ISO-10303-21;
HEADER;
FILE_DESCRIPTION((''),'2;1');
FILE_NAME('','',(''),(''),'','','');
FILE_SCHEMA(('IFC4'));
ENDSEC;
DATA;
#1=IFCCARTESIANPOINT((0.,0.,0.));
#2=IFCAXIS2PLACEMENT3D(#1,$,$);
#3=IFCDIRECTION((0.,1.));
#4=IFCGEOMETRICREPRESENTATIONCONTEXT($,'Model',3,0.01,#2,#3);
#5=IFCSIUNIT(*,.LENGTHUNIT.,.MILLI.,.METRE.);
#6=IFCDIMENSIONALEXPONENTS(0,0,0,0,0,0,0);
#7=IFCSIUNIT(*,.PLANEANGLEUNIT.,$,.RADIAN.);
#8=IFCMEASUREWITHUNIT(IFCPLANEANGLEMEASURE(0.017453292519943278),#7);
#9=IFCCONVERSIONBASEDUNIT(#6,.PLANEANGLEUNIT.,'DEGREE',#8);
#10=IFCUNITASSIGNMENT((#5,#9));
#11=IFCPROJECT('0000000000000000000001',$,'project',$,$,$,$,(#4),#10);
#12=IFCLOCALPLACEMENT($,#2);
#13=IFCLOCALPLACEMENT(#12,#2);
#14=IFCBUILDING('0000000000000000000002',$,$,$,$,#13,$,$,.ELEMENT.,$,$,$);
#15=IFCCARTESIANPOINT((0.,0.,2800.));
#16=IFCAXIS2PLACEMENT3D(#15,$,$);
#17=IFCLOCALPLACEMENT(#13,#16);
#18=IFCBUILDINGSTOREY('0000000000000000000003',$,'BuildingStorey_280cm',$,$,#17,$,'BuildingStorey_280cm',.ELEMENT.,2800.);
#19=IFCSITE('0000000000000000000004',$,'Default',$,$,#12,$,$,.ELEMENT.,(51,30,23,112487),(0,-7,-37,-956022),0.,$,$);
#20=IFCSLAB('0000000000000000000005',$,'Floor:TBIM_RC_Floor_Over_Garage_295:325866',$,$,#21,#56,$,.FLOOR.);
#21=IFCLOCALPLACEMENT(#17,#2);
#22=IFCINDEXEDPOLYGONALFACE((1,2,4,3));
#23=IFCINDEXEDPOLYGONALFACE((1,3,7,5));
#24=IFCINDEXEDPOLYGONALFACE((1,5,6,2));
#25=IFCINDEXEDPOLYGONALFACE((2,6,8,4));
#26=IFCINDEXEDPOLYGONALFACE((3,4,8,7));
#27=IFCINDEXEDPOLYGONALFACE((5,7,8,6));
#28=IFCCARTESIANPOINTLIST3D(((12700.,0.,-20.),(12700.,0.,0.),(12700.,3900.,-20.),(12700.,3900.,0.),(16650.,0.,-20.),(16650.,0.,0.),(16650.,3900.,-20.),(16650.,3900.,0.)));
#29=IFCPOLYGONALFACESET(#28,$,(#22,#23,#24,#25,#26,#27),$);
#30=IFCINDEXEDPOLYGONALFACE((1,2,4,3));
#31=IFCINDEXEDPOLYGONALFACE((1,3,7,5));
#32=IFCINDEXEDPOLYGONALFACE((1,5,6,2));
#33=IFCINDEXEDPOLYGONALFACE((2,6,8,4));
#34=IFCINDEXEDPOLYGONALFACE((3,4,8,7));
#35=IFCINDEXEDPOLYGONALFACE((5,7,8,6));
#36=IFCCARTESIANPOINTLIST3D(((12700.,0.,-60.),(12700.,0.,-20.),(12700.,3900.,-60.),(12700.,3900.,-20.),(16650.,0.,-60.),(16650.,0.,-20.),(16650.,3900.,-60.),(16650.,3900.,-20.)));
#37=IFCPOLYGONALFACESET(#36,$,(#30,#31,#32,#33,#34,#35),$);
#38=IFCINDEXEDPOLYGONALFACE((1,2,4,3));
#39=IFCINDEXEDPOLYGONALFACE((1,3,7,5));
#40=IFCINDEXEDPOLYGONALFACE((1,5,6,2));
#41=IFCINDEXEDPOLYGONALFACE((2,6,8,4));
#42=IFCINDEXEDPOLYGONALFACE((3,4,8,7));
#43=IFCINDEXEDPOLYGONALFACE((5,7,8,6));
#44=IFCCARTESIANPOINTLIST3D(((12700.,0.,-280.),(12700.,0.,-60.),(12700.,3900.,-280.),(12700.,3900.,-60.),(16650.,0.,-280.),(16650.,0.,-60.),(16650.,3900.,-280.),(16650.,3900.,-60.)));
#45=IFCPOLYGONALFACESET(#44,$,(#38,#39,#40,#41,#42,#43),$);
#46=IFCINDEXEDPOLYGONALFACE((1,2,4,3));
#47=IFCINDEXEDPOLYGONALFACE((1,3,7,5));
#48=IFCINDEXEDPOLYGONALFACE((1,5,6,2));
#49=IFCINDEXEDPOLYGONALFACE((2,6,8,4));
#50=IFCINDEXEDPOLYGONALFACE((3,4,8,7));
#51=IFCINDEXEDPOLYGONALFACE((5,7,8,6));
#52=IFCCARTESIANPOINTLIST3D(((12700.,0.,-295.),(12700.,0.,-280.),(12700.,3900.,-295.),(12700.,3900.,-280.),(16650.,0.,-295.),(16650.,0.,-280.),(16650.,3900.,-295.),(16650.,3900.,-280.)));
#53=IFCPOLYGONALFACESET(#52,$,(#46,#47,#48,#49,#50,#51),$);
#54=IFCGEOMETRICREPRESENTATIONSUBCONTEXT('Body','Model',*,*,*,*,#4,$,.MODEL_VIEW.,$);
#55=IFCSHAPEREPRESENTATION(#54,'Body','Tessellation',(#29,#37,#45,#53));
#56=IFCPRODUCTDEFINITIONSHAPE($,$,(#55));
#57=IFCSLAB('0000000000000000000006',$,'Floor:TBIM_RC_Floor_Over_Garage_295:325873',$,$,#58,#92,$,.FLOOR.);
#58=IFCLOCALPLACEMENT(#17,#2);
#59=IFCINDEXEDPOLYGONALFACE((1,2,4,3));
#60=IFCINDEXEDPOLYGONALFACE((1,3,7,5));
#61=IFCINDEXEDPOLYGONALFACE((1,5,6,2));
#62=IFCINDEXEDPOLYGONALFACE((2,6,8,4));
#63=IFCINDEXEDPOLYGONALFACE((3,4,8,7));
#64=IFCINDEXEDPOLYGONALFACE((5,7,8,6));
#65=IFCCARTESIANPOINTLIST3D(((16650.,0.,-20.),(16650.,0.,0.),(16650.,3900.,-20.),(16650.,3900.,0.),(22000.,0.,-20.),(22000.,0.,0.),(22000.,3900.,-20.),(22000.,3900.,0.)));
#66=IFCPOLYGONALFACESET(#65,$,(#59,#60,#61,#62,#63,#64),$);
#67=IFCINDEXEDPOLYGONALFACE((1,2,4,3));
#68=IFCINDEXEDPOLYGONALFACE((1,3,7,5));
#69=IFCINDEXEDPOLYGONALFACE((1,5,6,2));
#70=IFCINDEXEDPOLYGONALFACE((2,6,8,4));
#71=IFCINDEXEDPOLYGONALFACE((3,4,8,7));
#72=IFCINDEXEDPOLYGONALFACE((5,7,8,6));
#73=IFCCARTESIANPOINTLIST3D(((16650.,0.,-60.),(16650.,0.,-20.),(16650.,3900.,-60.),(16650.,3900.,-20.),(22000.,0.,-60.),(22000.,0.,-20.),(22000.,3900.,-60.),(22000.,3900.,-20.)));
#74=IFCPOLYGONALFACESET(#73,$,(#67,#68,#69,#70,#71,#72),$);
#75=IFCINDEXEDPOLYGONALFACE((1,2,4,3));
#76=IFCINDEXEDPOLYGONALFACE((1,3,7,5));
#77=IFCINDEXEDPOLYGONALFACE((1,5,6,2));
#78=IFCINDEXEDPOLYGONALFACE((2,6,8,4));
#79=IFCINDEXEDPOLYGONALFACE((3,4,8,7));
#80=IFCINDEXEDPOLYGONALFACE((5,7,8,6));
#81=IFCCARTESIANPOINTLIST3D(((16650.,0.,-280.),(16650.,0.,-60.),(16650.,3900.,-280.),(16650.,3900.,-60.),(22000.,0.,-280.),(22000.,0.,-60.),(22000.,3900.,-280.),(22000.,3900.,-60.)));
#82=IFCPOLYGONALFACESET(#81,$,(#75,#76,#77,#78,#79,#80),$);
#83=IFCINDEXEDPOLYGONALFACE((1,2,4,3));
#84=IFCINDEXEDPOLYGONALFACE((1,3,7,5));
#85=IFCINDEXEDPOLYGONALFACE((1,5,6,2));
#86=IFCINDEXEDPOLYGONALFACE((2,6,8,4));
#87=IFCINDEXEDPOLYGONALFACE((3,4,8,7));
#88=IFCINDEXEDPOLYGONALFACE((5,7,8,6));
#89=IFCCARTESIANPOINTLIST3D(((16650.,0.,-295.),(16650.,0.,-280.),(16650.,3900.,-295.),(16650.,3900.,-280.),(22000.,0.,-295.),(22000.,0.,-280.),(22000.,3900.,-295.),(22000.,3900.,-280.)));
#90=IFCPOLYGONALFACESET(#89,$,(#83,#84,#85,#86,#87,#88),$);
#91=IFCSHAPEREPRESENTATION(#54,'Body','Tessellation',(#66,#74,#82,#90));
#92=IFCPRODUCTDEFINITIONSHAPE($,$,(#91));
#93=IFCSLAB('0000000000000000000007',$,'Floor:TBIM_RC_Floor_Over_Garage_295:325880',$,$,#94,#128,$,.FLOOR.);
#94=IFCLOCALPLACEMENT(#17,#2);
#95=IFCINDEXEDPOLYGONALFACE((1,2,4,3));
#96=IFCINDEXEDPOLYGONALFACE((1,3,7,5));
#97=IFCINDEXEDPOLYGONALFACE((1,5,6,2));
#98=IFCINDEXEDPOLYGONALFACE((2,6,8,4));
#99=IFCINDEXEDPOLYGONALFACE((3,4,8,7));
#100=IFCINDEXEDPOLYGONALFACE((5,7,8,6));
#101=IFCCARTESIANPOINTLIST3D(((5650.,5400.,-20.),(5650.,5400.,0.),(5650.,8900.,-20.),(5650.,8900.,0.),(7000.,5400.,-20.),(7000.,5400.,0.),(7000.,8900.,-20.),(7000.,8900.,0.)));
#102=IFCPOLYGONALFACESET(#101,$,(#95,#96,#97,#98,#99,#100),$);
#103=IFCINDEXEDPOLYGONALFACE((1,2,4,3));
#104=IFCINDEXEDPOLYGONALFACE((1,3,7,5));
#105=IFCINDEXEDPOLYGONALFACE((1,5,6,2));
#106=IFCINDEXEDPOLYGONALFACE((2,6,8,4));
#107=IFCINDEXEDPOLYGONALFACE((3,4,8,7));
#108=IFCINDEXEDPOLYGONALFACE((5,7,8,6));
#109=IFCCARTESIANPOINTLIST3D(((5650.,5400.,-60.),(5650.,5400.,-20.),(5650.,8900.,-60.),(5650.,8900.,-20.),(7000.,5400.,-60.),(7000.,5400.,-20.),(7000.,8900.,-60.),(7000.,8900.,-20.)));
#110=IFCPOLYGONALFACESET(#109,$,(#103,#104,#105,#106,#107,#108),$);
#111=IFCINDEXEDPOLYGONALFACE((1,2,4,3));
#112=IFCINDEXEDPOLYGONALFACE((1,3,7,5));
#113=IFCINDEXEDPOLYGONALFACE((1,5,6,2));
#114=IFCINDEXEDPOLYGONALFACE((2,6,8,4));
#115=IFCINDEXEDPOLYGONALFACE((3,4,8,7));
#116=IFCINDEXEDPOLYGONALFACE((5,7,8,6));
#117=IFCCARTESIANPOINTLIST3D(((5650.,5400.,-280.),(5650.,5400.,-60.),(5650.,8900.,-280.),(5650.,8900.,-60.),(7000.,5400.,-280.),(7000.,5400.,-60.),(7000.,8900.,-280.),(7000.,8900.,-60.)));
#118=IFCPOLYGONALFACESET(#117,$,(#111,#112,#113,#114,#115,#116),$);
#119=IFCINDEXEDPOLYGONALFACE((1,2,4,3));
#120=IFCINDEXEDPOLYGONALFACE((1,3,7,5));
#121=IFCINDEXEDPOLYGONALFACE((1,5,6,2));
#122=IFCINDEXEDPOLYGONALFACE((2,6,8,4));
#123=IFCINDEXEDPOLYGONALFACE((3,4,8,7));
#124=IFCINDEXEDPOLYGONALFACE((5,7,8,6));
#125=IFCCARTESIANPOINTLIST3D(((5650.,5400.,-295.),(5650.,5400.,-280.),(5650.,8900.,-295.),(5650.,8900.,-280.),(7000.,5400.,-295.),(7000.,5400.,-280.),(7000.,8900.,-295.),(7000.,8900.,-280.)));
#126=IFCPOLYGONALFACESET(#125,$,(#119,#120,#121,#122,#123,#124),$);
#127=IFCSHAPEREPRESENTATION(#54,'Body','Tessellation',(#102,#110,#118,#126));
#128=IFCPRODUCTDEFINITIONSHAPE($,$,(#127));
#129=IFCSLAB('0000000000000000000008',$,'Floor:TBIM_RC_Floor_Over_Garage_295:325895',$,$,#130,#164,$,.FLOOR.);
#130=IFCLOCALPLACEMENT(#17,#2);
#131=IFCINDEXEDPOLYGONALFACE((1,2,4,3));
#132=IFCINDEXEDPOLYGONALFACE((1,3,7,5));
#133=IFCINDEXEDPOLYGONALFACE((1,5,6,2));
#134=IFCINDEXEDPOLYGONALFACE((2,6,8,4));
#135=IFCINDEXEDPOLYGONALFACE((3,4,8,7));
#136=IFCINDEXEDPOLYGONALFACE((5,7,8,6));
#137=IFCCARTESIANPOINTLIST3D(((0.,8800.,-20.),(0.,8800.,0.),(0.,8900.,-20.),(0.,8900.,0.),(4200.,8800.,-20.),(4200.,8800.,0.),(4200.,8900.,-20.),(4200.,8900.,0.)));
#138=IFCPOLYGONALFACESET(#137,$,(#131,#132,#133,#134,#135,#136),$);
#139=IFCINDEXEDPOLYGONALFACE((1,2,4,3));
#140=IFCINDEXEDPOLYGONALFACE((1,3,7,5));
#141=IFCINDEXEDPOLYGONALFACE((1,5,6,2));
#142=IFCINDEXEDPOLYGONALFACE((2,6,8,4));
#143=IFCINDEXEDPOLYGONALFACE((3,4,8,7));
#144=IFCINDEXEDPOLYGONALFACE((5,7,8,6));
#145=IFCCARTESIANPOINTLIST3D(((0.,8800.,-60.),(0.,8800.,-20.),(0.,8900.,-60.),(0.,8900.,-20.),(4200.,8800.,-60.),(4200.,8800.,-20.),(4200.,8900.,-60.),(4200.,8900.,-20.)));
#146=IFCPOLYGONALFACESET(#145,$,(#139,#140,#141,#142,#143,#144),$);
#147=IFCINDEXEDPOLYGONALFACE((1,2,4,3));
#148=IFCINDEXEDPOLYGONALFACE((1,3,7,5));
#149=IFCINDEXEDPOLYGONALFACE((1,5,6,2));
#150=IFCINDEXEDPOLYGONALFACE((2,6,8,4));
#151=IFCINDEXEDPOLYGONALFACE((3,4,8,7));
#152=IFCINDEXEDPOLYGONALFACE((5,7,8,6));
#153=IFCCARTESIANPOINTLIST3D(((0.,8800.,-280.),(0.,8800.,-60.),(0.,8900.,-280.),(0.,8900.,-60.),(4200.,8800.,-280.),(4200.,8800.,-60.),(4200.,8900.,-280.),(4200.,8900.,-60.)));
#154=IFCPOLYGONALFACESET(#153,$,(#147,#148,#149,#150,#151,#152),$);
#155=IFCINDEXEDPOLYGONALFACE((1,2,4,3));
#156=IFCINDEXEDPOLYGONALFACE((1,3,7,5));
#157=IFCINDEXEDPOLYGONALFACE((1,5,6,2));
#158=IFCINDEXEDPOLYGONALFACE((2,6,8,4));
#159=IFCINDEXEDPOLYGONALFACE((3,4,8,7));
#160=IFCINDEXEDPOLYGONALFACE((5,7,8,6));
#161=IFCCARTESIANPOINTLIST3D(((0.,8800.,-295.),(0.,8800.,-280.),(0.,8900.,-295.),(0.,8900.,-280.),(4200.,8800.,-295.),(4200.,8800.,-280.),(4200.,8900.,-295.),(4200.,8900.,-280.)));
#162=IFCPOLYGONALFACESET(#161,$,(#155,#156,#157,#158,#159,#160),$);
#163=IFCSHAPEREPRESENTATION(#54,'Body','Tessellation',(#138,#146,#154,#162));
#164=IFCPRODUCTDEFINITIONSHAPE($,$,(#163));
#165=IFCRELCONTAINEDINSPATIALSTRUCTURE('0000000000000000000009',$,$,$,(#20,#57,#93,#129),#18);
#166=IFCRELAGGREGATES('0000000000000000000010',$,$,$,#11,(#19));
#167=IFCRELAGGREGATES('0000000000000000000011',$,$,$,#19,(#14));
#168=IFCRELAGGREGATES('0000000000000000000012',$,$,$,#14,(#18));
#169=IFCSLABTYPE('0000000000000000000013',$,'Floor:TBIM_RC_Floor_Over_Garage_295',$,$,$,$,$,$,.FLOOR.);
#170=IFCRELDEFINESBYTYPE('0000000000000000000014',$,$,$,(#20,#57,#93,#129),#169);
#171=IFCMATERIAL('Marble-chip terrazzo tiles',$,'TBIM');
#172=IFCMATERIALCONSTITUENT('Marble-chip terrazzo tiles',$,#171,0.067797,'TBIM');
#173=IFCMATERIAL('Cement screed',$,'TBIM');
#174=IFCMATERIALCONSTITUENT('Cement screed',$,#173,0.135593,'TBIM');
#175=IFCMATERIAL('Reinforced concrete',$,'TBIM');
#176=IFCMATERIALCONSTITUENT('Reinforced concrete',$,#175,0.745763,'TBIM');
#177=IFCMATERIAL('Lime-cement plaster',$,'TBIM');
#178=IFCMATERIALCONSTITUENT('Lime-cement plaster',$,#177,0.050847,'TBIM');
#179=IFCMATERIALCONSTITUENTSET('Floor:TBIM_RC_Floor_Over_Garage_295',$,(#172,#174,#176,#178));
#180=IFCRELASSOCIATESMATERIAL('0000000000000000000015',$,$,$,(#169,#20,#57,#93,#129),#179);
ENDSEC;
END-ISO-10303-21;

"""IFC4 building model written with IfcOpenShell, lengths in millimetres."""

from ifc_helpers import new_model, entity, si_unit, converted_unit, direction, frame, origin, place, context, subcontext, project, spatial, indexed_curve, outline, extrude, material, constituent, constituent_set, type_object, element, save


model = new_model("IFC4")

# Units and contexts
model_context = context("Model", 3, precision=0.01, world=origin(), true_north=direction((0.0, 1.0)))
body_context = subcontext(model_context, "Body", "Model", "MODEL_VIEW")
ifc_project = project(units=[si_unit("LENGTHUNIT", "METRE", prefix="MILLI"), converted_unit("PLANEANGLEUNIT", "DEGREE", entity("IfcPlaneAngleMeasure", 0.017453292519943278), si_unit("PLANEANGLEUNIT", "RADIAN"), dimensions=[0, 0, 0, 0, 0, 0, 0])], contexts=[model_context])

# Site, building, storey
site_placement = place(None, origin())
site = spatial("IfcSite", under=ifc_project, at=site_placement, Name="Default", CompositionType="ELEMENT", RefLatitude=(51, 30, 23, 112487), RefLongitude=(0, -7, -37, -956022), RefElevation=0.0)
building_placement = place(site_placement, origin())
building = spatial("IfcBuilding", under=site, at=building_placement, CompositionType="ELEMENT")
storey_placement = place(building_placement, frame((0.0, 0.0, 2800.0)))
storey = spatial("IfcBuildingStorey", under=building, at=storey_placement, Name="BuildingStorey_280cm", LongName="BuildingStorey_280cm", CompositionType="ELEMENT", Elevation=2800.0)

# Slabs
ifc_material_1 = material(Name="Marble-chip terrazzo tiles", Category="TBIM")
ifc_constituent_1 = constituent(ifc_material_1, Name="Marble-chip terrazzo tiles", Category="TBIM", fraction=0.067797)
ifc_material_2 = material(Name="Cement screed", Category="TBIM")
ifc_constituent_2 = constituent(ifc_material_2, Name="Cement screed", Category="TBIM", fraction=0.135593)
ifc_material_3 = material(Name="Reinforced concrete", Category="TBIM")
ifc_constituent_3 = constituent(ifc_material_3, Name="Reinforced concrete", Category="TBIM", fraction=0.745763)
ifc_material_4 = material(Name="Lime-cement plaster", Category="TBIM")
ifc_constituent_4 = constituent(ifc_material_4, Name="Lime-cement plaster", Category="TBIM", fraction=0.050847)
ifc_constituent_set_1 = constituent_set(constituents=[ifc_constituent_1, ifc_constituent_2, ifc_constituent_3, ifc_constituent_4], Name="Floor:TBIM_RC_Floor_Over_Garage_295")
slab_type_1 = type_object("IfcSlabType", Name="Floor:TBIM_RC_Floor_Over_Garage_295", PredefinedType="FLOOR", material=ifc_constituent_set_1)
slab_1_placement = place(storey_placement, origin())
element("IfcSlab", 1, at=slab_1_placement, inside=storey, type_object=slab_type_1, material=ifc_constituent_set_1, Name="Floor:TBIM_RC_Floor_Over_Garage_295:325866", PredefinedType="FLOOR", context=body_context, shape_type="SweptSolid", body=[
    extrude(outline(indexed_curve([(-1975.0, -1950.0), (1975.0, -1950.0), (1975.0, 1950.0), (-1975.0, 1950.0), (-1975.0, -1950.0)], self_intersect=False)), frame((14675.0, 1950.0, -20.0), z_axis=(0.0, 0.0, 1.0), x_axis=(-1.0, 0.0, 0.0)), (0.0, 0.0, 1.0), 20.0),
    extrude(outline(indexed_curve([(-1975.0, -1950.0), (1975.0, -1950.0), (1975.0, 1950.0), (-1975.0, 1950.0), (-1975.0, -1950.0)], self_intersect=False)), frame((14675.0, 1950.0, -60.0), z_axis=(0.0, 0.0, 1.0), x_axis=(-1.0, 0.0, 0.0)), (0.0, 0.0, 1.0), 40.0),
    extrude(outline(indexed_curve([(-1975.0, -1950.0), (1975.0, -1950.0), (1975.0, 1950.0), (-1975.0, 1950.0), (-1975.0, -1950.0)], self_intersect=False)), frame((14675.0, 1950.0, -280.0), z_axis=(0.0, 0.0, 1.0), x_axis=(-1.0, 0.0, 0.0)), (0.0, 0.0, 1.0), 220.0),
    extrude(outline(indexed_curve([(-1975.0, -1950.0), (1975.0, -1950.0), (1975.0, 1950.0), (-1975.0, 1950.0), (-1975.0, -1950.0)], self_intersect=False)), frame((14675.0, 1950.0, -295.0), z_axis=(0.0, 0.0, 1.0), x_axis=(-1.0, 0.0, 0.0)), (0.0, 0.0, 1.0), 15.0),
])
slab_2_placement = place(storey_placement, origin())
element("IfcSlab", 2, at=slab_2_placement, inside=storey, type_object=slab_type_1, material=ifc_constituent_set_1, Name="Floor:TBIM_RC_Floor_Over_Garage_295:325873", PredefinedType="FLOOR", context=body_context, shape_type="SweptSolid", body=[
    extrude(outline(indexed_curve([(-2675.0, -1950.0), (2675.0, -1950.0), (2675.0, 1950.0), (-2675.0, 1950.0), (-2675.0, -1950.0)], self_intersect=False)), frame((19325.0, 1950.0, -20.0), z_axis=(0.0, 0.0, 1.0), x_axis=(-1.0, 0.0, 0.0)), (0.0, 0.0, 1.0), 20.0),
    extrude(outline(indexed_curve([(-2675.0, -1950.0), (2675.0, -1950.0), (2675.0, 1950.0), (-2675.0, 1950.0), (-2675.0, -1950.0)], self_intersect=False)), frame((19325.0, 1950.0, -60.0), z_axis=(0.0, 0.0, 1.0), x_axis=(-1.0, 0.0, 0.0)), (0.0, 0.0, 1.0), 40.0),
    extrude(outline(indexed_curve([(-2675.0, -1950.0), (2675.0, -1950.0), (2675.0, 1950.0), (-2675.0, 1950.0), (-2675.0, -1950.0)], self_intersect=False)), frame((19325.0, 1950.0, -280.0), z_axis=(0.0, 0.0, 1.0), x_axis=(-1.0, 0.0, 0.0)), (0.0, 0.0, 1.0), 220.0),
    extrude(outline(indexed_curve([(-2675.0, -1950.0), (2675.0, -1950.0), (2675.0, 1950.0), (-2675.0, 1950.0), (-2675.0, -1950.0)], self_intersect=False)), frame((19325.0, 1950.0, -295.0), z_axis=(0.0, 0.0, 1.0), x_axis=(-1.0, 0.0, 0.0)), (0.0, 0.0, 1.0), 15.0),
])
slab_3_placement = place(storey_placement, origin())
element("IfcSlab", 3, at=slab_3_placement, inside=storey, type_object=slab_type_1, material=ifc_constituent_set_1, Name="Floor:TBIM_RC_Floor_Over_Garage_295:325880", PredefinedType="FLOOR", context=body_context, shape_type="SweptSolid", body=[
    extrude(outline(indexed_curve([(-675.0, -1750.0), (675.0, -1750.0), (675.0, 1750.0), (-675.0, 1750.0), (-675.0, -1750.0)], self_intersect=False)), frame((6325.0, 7150.0, -20.0), z_axis=(0.0, 0.0, 1.0), x_axis=(-1.0, 0.0, 0.0)), (0.0, 0.0, 1.0), 20.0),
    extrude(outline(indexed_curve([(-675.0, -1750.0), (675.0, -1750.0), (675.0, 1750.0), (-675.0, 1750.0), (-675.0, -1750.0)], self_intersect=False)), frame((6325.0, 7150.0, -60.0), z_axis=(0.0, 0.0, 1.0), x_axis=(-1.0, 0.0, 0.0)), (0.0, 0.0, 1.0), 40.0),
    extrude(outline(indexed_curve([(-675.0, -1750.0), (675.0, -1750.0), (675.0, 1750.0), (-675.0, 1750.0), (-675.0, -1750.0)], self_intersect=False)), frame((6325.0, 7150.0, -280.0), z_axis=(0.0, 0.0, 1.0), x_axis=(-1.0, 0.0, 0.0)), (0.0, 0.0, 1.0), 220.0),
    extrude(outline(indexed_curve([(-675.0, -1750.0), (675.0, -1750.0), (675.0, 1750.0), (-675.0, 1750.0), (-675.0, -1750.0)], self_intersect=False)), frame((6325.0, 7150.0, -295.0), z_axis=(0.0, 0.0, 1.0), x_axis=(-1.0, 0.0, 0.0)), (0.0, 0.0, 1.0), 15.0),
])
slab_4_placement = place(storey_placement, origin())
element("IfcSlab", 4, at=slab_4_placement, inside=storey, type_object=slab_type_1, material=ifc_constituent_set_1, Name="Floor:TBIM_RC_Floor_Over_Garage_295:325895", PredefinedType="FLOOR", context=body_context, shape_type="SweptSolid", body=[
    extrude(outline(indexed_curve([(-2100.0, -50.0), (2100.0, -50.0), (2100.0, 50.0), (-2100.0, 50.0), (-2100.0, -50.0)], self_intersect=False)), frame((2100.0, 8850.0, -20.0), z_axis=(0.0, 0.0, 1.0), x_axis=(-1.0, 0.0, 0.0)), (0.0, 0.0, 1.0), 20.0),
    extrude(outline(indexed_curve([(-2100.0, -50.0), (2100.0, -50.0), (2100.0, 50.0), (-2100.0, 50.0), (-2100.0, -50.0)], self_intersect=False)), frame((2100.0, 8850.0, -60.0), z_axis=(0.0, 0.0, 1.0), x_axis=(-1.0, 0.0, 0.0)), (0.0, 0.0, 1.0), 40.0),
    extrude(outline(indexed_curve([(-2100.0, -50.0), (2100.0, -50.0), (2100.0, 50.0), (-2100.0, 50.0), (-2100.0, -50.0)], self_intersect=False)), frame((2100.0, 8850.0, -280.0), z_axis=(0.0, 0.0, 1.0), x_axis=(-1.0, 0.0, 0.0)), (0.0, 0.0, 1.0), 220.0),
    extrude(outline(indexed_curve([(-2100.0, -50.0), (2100.0, -50.0), (2100.0, 50.0), (-2100.0, 50.0), (-2100.0, -50.0)], self_intersect=False)), frame((2100.0, 8850.0, -295.0), z_axis=(0.0, 0.0, 1.0), x_axis=(-1.0, 0.0, 0.0)), (0.0, 0.0, 1.0), 15.0),
])

save(model, "model.ifc")
